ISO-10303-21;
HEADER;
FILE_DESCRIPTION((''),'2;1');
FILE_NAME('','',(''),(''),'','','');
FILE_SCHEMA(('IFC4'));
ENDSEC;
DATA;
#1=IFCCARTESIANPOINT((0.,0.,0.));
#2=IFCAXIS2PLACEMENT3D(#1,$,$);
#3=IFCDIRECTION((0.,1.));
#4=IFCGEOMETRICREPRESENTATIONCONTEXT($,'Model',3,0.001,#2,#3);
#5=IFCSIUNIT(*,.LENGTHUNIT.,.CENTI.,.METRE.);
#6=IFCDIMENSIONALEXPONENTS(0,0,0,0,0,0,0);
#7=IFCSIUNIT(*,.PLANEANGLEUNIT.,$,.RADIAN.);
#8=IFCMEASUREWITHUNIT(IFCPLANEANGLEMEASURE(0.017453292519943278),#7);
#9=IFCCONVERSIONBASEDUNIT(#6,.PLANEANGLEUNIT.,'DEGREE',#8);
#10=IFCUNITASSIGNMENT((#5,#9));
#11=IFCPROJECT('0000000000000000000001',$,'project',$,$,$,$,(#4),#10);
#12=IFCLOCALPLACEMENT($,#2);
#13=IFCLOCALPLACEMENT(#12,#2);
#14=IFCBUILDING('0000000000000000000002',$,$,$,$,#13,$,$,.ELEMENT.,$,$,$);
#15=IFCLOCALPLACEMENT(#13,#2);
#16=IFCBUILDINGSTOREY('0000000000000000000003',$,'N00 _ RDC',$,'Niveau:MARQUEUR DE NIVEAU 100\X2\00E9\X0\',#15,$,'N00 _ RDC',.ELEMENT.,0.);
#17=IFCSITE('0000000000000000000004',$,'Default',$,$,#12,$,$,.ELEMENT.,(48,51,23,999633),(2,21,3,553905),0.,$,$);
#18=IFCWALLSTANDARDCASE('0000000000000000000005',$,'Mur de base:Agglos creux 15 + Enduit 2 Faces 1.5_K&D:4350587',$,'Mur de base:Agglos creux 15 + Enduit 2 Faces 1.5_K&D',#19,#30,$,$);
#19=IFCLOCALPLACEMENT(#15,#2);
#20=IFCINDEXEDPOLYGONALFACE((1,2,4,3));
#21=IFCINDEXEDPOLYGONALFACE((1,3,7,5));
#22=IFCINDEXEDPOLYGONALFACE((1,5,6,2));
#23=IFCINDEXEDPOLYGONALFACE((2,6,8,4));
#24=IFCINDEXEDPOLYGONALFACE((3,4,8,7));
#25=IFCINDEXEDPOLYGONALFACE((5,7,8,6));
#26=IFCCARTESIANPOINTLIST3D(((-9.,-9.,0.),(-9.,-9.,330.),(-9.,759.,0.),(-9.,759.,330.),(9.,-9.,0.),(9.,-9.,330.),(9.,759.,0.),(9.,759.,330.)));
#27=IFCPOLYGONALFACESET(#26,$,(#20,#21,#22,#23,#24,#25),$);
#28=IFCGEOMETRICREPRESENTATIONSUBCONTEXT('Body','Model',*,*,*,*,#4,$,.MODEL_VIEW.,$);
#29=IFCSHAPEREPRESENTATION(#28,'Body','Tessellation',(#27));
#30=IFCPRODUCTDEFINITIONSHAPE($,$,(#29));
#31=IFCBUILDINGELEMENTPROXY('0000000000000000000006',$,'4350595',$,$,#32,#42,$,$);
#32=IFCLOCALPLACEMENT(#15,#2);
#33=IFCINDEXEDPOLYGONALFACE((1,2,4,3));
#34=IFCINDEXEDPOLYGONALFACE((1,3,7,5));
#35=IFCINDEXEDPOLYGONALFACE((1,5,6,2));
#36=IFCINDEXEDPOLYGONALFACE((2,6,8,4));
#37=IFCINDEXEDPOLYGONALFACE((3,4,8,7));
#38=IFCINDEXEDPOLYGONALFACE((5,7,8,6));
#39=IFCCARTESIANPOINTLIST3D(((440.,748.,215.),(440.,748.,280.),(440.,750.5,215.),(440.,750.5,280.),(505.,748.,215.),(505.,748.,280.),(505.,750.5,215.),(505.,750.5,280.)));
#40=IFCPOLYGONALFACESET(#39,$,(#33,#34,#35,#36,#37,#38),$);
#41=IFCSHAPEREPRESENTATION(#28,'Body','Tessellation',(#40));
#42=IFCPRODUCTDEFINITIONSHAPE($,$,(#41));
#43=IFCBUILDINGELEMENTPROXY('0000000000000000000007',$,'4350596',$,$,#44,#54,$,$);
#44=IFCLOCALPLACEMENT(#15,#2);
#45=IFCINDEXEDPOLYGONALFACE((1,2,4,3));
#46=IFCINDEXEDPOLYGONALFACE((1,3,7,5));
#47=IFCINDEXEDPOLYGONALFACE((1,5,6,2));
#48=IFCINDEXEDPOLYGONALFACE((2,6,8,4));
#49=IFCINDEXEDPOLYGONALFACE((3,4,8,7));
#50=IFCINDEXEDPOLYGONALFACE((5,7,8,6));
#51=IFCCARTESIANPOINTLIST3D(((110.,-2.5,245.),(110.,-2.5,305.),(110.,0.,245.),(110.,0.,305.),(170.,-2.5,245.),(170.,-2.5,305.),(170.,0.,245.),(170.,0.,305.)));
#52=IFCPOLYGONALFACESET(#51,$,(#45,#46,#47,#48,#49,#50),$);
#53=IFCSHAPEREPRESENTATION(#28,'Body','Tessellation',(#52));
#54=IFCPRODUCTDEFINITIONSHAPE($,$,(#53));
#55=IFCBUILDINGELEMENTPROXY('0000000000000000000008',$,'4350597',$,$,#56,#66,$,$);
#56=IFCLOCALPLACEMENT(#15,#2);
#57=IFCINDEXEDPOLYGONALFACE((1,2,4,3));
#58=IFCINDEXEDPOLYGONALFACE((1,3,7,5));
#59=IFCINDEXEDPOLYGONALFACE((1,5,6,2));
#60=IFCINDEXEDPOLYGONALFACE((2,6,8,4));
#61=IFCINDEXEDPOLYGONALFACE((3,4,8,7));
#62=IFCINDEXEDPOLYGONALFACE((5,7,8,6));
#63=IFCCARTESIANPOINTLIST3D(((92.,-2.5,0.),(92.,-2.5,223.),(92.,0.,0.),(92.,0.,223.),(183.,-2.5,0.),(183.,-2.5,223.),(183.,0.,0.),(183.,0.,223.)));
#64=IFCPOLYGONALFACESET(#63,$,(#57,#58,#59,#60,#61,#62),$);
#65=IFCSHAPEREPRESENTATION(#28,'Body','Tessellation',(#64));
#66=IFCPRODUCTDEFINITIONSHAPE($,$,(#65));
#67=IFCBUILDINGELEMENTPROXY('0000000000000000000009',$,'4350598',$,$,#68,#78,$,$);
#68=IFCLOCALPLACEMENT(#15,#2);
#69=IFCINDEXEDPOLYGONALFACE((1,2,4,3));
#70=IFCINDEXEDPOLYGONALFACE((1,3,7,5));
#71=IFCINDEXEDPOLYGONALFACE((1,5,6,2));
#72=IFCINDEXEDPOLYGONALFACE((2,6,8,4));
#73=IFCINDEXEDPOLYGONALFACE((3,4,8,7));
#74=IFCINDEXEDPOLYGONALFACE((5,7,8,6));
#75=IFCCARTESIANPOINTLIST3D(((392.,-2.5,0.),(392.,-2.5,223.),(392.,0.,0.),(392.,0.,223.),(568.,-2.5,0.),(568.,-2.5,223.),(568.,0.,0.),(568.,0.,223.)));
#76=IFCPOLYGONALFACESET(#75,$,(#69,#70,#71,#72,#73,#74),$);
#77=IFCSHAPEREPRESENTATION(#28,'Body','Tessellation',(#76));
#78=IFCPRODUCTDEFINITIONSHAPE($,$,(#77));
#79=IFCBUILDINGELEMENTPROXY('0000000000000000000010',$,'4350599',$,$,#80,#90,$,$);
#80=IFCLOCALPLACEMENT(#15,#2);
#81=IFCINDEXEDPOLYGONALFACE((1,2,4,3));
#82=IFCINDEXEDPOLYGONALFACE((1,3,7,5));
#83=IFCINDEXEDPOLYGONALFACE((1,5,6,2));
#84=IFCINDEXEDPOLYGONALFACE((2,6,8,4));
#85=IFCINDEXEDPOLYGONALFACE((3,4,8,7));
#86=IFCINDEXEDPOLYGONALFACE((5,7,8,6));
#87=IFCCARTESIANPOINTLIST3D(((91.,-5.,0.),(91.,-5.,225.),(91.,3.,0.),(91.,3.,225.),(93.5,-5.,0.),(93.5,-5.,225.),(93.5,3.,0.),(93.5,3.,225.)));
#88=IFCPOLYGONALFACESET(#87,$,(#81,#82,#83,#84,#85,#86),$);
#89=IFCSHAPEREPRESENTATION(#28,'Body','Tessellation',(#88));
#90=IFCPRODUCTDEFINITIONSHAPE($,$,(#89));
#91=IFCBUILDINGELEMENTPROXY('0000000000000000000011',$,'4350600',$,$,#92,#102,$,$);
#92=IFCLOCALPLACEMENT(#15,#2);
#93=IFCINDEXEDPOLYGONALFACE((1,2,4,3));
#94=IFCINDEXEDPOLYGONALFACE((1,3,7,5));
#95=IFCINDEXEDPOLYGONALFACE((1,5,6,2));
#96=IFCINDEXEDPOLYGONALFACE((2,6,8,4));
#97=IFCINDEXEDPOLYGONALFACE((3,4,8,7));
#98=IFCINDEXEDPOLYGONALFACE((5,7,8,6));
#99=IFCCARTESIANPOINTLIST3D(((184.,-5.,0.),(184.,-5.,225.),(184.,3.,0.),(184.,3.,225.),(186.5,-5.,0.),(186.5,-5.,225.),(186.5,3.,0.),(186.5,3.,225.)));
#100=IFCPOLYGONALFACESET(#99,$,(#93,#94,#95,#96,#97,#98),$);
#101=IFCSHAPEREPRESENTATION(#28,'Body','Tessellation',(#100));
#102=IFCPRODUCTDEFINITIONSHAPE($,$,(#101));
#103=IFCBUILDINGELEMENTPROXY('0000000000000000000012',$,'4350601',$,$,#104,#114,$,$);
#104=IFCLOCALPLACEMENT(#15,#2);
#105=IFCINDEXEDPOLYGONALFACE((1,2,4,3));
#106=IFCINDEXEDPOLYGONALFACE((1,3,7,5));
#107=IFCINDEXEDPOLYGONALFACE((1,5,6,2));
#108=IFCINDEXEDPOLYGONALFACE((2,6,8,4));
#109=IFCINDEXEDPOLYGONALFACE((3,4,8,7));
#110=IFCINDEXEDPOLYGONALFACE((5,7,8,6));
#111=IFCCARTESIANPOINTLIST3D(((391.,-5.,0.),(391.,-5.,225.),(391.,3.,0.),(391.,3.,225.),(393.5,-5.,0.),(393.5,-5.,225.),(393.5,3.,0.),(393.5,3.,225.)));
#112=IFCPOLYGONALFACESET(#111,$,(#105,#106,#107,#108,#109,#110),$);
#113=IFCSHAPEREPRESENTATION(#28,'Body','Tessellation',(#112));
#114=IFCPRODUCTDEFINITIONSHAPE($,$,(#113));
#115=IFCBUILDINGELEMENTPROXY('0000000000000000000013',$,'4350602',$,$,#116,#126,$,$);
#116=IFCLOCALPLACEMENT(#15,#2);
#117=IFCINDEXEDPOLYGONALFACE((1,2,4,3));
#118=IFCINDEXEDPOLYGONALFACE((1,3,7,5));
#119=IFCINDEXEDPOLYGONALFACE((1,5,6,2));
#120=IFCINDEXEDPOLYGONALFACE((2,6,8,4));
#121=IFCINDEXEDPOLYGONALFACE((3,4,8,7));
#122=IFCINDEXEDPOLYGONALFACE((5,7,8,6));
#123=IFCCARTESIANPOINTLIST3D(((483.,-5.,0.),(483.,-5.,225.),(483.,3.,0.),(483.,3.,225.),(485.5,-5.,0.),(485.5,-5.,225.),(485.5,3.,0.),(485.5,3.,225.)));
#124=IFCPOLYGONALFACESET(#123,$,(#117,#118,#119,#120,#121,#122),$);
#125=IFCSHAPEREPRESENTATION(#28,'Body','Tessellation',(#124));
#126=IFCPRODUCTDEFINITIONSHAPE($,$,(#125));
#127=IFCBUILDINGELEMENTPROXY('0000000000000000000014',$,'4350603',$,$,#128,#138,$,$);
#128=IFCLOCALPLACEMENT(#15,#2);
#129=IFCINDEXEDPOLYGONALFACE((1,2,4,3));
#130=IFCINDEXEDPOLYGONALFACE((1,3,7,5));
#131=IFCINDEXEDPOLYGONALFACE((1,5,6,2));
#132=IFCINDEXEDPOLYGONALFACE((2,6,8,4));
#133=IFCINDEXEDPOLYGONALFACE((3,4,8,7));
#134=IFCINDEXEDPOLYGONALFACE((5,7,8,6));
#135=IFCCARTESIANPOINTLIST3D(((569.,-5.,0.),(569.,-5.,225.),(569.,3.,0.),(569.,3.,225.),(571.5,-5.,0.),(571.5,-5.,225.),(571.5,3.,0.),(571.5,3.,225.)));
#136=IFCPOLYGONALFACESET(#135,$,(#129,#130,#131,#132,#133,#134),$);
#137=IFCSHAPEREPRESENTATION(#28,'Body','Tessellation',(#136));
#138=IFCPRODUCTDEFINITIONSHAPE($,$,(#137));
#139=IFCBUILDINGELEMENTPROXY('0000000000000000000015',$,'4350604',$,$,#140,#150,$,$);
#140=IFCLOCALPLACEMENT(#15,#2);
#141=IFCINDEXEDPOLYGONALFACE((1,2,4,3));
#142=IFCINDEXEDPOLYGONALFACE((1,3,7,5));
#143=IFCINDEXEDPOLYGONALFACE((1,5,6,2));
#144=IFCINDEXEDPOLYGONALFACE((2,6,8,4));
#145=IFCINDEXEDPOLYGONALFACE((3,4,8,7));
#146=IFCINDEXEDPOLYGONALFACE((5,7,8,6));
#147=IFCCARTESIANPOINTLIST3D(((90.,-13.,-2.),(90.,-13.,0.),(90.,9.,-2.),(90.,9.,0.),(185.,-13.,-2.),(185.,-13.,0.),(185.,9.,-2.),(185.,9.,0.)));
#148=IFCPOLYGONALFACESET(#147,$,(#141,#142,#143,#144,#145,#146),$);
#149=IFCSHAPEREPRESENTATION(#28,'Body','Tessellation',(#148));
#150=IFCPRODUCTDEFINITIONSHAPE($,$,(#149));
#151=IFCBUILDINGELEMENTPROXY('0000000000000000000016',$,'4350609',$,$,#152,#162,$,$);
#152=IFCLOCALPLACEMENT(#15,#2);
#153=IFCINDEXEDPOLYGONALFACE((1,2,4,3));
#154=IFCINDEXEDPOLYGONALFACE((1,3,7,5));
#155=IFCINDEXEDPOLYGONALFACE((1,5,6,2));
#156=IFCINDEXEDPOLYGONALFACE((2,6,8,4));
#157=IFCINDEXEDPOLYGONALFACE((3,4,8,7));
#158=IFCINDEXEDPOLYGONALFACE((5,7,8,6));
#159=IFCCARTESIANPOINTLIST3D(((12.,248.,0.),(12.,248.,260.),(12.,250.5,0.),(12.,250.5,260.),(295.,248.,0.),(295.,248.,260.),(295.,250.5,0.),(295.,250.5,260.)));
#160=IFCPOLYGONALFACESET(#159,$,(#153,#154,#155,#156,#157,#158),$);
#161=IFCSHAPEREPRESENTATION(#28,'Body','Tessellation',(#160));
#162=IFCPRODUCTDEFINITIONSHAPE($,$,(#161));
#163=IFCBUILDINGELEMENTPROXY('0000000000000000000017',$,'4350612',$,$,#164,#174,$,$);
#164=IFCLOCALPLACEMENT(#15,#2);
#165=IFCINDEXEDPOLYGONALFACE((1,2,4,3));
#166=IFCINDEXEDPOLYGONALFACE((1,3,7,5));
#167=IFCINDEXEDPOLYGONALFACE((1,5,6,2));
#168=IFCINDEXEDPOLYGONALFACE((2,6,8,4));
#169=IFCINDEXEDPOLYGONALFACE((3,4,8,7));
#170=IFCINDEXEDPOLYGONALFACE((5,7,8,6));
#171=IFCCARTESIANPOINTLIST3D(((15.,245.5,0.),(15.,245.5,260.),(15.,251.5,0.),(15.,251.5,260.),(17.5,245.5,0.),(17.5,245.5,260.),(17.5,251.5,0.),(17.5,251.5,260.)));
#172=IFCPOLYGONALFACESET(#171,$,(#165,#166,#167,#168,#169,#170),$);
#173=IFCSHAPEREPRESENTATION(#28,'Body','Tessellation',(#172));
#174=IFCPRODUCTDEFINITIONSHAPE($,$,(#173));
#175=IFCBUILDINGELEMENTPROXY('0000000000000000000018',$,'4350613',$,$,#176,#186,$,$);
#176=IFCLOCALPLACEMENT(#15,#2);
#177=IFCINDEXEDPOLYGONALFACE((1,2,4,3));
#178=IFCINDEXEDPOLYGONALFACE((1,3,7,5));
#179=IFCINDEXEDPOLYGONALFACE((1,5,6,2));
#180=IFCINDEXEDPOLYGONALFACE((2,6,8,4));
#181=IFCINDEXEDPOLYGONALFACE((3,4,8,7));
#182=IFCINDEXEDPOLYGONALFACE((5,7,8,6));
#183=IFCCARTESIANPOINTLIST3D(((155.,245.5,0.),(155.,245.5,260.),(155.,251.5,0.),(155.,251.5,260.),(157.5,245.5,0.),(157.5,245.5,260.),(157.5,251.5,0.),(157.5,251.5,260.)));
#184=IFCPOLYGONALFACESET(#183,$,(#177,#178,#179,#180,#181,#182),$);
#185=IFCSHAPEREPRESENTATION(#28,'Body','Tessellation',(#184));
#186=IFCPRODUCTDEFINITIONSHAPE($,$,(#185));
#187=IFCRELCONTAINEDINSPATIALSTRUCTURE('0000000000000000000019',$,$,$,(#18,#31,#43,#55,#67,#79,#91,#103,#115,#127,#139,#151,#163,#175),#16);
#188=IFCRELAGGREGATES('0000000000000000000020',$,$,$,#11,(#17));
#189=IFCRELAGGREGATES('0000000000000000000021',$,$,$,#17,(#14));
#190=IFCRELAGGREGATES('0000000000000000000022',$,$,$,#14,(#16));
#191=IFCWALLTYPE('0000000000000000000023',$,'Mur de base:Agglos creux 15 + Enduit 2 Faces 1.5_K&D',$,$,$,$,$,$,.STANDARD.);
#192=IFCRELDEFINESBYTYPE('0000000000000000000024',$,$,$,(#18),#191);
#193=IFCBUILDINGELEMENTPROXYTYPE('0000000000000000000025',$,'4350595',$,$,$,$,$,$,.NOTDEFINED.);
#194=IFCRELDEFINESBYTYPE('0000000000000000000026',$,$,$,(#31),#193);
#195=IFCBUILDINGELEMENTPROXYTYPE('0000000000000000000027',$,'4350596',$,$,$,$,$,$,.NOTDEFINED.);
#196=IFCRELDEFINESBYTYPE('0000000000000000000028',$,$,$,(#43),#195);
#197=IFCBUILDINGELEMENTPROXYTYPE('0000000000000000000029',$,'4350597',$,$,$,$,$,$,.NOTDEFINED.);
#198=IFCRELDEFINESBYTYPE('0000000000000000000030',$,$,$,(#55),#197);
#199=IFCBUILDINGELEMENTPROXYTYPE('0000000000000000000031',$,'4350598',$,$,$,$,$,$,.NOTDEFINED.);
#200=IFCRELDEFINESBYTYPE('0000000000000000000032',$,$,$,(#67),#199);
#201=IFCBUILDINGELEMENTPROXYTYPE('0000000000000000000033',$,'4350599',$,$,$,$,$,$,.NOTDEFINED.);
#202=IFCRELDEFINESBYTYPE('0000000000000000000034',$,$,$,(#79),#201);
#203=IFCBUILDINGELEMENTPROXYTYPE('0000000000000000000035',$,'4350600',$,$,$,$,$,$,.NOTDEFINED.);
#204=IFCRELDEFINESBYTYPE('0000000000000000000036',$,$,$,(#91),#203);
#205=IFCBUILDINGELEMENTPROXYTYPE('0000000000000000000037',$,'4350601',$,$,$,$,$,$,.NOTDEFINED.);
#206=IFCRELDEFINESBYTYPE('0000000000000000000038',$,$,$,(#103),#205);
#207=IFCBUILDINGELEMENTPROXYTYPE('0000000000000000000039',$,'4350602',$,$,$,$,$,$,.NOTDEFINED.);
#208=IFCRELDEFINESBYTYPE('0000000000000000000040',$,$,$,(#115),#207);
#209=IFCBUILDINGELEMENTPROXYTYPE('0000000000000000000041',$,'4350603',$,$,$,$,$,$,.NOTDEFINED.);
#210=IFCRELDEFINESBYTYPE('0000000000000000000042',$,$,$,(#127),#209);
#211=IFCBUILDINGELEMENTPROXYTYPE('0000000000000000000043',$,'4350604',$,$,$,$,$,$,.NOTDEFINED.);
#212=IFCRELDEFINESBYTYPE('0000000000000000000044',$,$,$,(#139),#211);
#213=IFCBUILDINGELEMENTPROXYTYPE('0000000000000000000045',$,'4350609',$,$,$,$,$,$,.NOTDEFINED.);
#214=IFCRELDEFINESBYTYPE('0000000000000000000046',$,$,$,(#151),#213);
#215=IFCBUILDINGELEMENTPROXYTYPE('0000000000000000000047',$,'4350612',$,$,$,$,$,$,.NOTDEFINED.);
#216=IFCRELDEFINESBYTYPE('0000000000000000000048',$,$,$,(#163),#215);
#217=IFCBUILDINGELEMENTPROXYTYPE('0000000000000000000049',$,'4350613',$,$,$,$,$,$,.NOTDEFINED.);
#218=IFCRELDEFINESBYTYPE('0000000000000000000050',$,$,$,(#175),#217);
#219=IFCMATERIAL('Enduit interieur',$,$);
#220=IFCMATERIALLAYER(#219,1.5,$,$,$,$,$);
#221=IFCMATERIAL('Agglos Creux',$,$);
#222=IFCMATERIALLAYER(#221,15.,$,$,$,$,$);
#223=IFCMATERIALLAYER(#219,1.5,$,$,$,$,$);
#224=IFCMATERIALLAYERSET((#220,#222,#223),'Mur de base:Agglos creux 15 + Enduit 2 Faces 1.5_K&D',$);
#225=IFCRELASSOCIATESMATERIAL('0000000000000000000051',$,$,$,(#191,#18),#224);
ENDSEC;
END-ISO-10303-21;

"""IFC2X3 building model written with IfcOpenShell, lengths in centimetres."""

from ifc_helpers import new_model, entity, si_unit, converted_unit, direction, frame, frame_2d, origin, origin_2d_with_axis, place, context, subcontext, project, spatial, rectangle, extrude, material, layer, layer_set, layer_usage, type_object, element, save


model = new_model("IFC2X3")

# Units and contexts
model_context = context("Model", 3, precision=0.001, world=origin(), true_north=direction((0.0, 1.0)))
body_context = subcontext(model_context, "Body", "Model", "MODEL_VIEW")
ifc_project = project(units=[si_unit("LENGTHUNIT", "METRE", prefix="CENTI"), converted_unit("PLANEANGLEUNIT", "DEGREE", entity("IfcPlaneAngleMeasure", 0.017453292519943278), si_unit("PLANEANGLEUNIT", "RADIAN"), dimensions=[0, 0, 0, 0, 0, 0, 0])], contexts=[model_context])

# Site, building, storey
site_placement = place(None, origin())
site = spatial("IfcSite", under=ifc_project, at=site_placement, Name="Default", CompositionType="ELEMENT", RefLatitude=(48, 51, 23, 999633), RefLongitude=(2, 21, 3, 553905), RefElevation=0.0)
building_placement = place(site_placement, origin())
building = spatial("IfcBuilding", under=site, at=building_placement, CompositionType="ELEMENT")
storey_placement = place(building_placement, origin())
storey = spatial("IfcBuildingStorey", under=building, at=storey_placement, Name="N00 _ RDC", ObjectType="Niveau:MARQUEUR DE NIVEAU 100é", LongName="N00 _ RDC", CompositionType="ELEMENT", Elevation=0.0)

# Wall
ifc_material_1 = material(Name="Enduit interieur")
ifc_layer_1 = layer(ifc_material_1, 1.5)
ifc_material_2 = material(Name="Agglos Creux")
ifc_layer_2 = layer(ifc_material_2, 15.0)
ifc_layer_3 = layer(ifc_material_1, 1.5)
ifc_layer_set = layer_set([ifc_layer_1, ifc_layer_2, ifc_layer_3], Name="Mur de base:Agglos creux 15 + Enduit 2 Faces 1.5_K&D")
ifc_layer_usage = layer_usage(ifc_layer_set, "AXIS2", "NEGATIVE", 9.0)
wall_type = type_object("IfcWallType", Name="Mur de base:Agglos creux 15 + Enduit 2 Faces 1.5_K&D", PredefinedType="STANDARD", material=ifc_layer_set)
wall_placement = place(storey_placement, frame((0.0, -9.0, 0.0), z_axis=(0.0, 0.0, 1.0), x_axis=(0.0, 1.0, 0.0)))
element("IfcWallStandardCase", 1, at=wall_placement, inside=storey, type_object=wall_type, material=ifc_layer_usage, Name="Mur de base:Agglos creux 15 + Enduit 2 Faces 1.5_K&D:4350587", ObjectType="Mur de base:Agglos creux 15 + Enduit 2 Faces 1.5_K&D", context=body_context, shape_type="SweptSolid", body=[
    extrude(rectangle(XDim=768.0, YDim=18.0, at=frame_2d((384.0, 0.0), x_axis=(-1.0, 0.0))), origin(), (0.0, 0.0, 1.0), 330.0),
])

# Building element proxies
building_element_proxy_type_1 = type_object("IfcBuildingElementProxyType", Name="4350595", PredefinedType="NOTDEFINED")
proxy_1_placement = place(storey_placement, origin())
element("IfcBuildingElementProxy", 2, at=proxy_1_placement, inside=storey, type_object=building_element_proxy_type_1, Name="4350595", context=body_context, shape_type="SweptSolid", body=[
    extrude(rectangle(XDim=65.0, YDim=2.5, at=frame_2d((0.0, 0.0), x_axis=(1.0, 0.0))), frame((472.5, 749.25, 215.0)), (0.0, 0.0, 1.0), 65.0),
])
building_element_proxy_type_2 = type_object("IfcBuildingElementProxyType", Name="4350596", PredefinedType="NOTDEFINED")
proxy_2_placement = place(storey_placement, origin())
element("IfcBuildingElementProxy", 3, at=proxy_2_placement, inside=storey, type_object=building_element_proxy_type_2, Name="4350596", context=body_context, shape_type="SweptSolid", body=[
    extrude(rectangle(XDim=60.0, YDim=2.5, at=origin_2d_with_axis()), frame((140.0, -1.25, 245.0)), (0.0, 0.0, 1.0), 60.0),
])
building_element_proxy_type_3 = type_object("IfcBuildingElementProxyType", Name="4350597", PredefinedType="NOTDEFINED")
proxy_3_placement = place(storey_placement, origin())
element("IfcBuildingElementProxy", 4, at=proxy_3_placement, inside=storey, type_object=building_element_proxy_type_3, Name="4350597", context=body_context, shape_type="SweptSolid", body=[
    extrude(rectangle(XDim=91.0, YDim=2.5, at=frame_2d((0.0, 0.0), x_axis=(1.0, 0.0))), frame((137.5, -1.25, 0.0)), (0.0, 0.0, 1.0), 223.0),
])
building_element_proxy_type_4 = type_object("IfcBuildingElementProxyType", Name="4350598", PredefinedType="NOTDEFINED")
proxy_4_placement = place(storey_placement, origin())
element("IfcBuildingElementProxy", 5, at=proxy_4_placement, inside=storey, type_object=building_element_proxy_type_4, Name="4350598", context=body_context, shape_type="SweptSolid", body=[
    extrude(rectangle(XDim=176.0, YDim=2.5, at=frame_2d((0.0, 0.0), x_axis=(1.0, 0.0))), frame((480.0, -1.25, 0.0)), (0.0, 0.0, 1.0), 223.0),
])
building_element_proxy_type_5 = type_object("IfcBuildingElementProxyType", Name="4350599", PredefinedType="NOTDEFINED")
proxy_5_placement = place(storey_placement, origin())
element("IfcBuildingElementProxy", 6, at=proxy_5_placement, inside=storey, type_object=building_element_proxy_type_5, Name="4350599", context=body_context, shape_type="SweptSolid", body=[
    extrude(rectangle(XDim=2.5, YDim=8.0, at=frame_2d((0.0, 0.0), x_axis=(1.0, 0.0))), frame((92.25, -1.0, 0.0)), (0.0, 0.0, 1.0), 225.0),
])
building_element_proxy_type_6 = type_object("IfcBuildingElementProxyType", Name="4350600", PredefinedType="NOTDEFINED")
proxy_6_placement = place(storey_placement, origin())
element("IfcBuildingElementProxy", 7, at=proxy_6_placement, inside=storey, type_object=building_element_proxy_type_6, Name="4350600", context=body_context, shape_type="SweptSolid", body=[
    extrude(rectangle(XDim=2.5, YDim=8.0, at=frame_2d((0.0, 0.0), x_axis=(1.0, 0.0))), frame((185.25, -1.0, 0.0)), (0.0, 0.0, 1.0), 225.0),
])
building_element_proxy_type_7 = type_object("IfcBuildingElementProxyType", Name="4350601", PredefinedType="NOTDEFINED")
proxy_7_placement = place(storey_placement, origin())
element("IfcBuildingElementProxy", 8, at=proxy_7_placement, inside=storey, type_object=building_element_proxy_type_7, Name="4350601", context=body_context, shape_type="SweptSolid", body=[
    extrude(rectangle(XDim=2.5, YDim=8.0, at=frame_2d((0.0, 0.0), x_axis=(1.0, 0.0))), frame((392.25, -1.0, 0.0)), (0.0, 0.0, 1.0), 225.0),
])
building_element_proxy_type_8 = type_object("IfcBuildingElementProxyType", Name="4350602", PredefinedType="NOTDEFINED")
proxy_8_placement = place(storey_placement, origin())
element("IfcBuildingElementProxy", 9, at=proxy_8_placement, inside=storey, type_object=building_element_proxy_type_8, Name="4350602", context=body_context, shape_type="SweptSolid", body=[
    extrude(rectangle(XDim=2.5, YDim=8.0, at=frame_2d((0.0, 0.0), x_axis=(1.0, 0.0))), frame((484.25, -1.0, 0.0)), (0.0, 0.0, 1.0), 225.0),
])
building_element_proxy_type_9 = type_object("IfcBuildingElementProxyType", Name="4350603", PredefinedType="NOTDEFINED")
proxy_9_placement = place(storey_placement, origin())
element("IfcBuildingElementProxy", 10, at=proxy_9_placement, inside=storey, type_object=building_element_proxy_type_9, Name="4350603", context=body_context, shape_type="SweptSolid", body=[
    extrude(rectangle(XDim=2.5, YDim=8.0, at=frame_2d((0.0, 0.0), x_axis=(1.0, 0.0))), frame((570.25, -1.0, 0.0)), (0.0, 0.0, 1.0), 225.0),
])
building_element_proxy_type_10 = type_object("IfcBuildingElementProxyType", Name="4350604", PredefinedType="NOTDEFINED")
proxy_10_placement = place(storey_placement, origin())
element("IfcBuildingElementProxy", 11, at=proxy_10_placement, inside=storey, type_object=building_element_proxy_type_10, Name="4350604", context=body_context, shape_type="SweptSolid", body=[
    extrude(rectangle(XDim=95.0, YDim=22.0, at=origin_2d_with_axis()), frame((137.5, -2.0, -2.0)), (0.0, 0.0, 1.0), 2.0),
])
building_element_proxy_type_11 = type_object("IfcBuildingElementProxyType", Name="4350609", PredefinedType="NOTDEFINED")
proxy_11_placement = place(storey_placement, origin())
element("IfcBuildingElementProxy", 12, at=proxy_11_placement, inside=storey, type_object=building_element_proxy_type_11, Name="4350609", context=body_context, shape_type="SweptSolid", body=[
    extrude(rectangle(XDim=283.0, YDim=2.5, at=frame_2d((0.0, 0.0), x_axis=(1.0, 0.0))), frame((153.5, 249.25, 0.0)), (0.0, 0.0, 1.0), 260.0),
])
building_element_proxy_type_12 = type_object("IfcBuildingElementProxyType", Name="4350612", PredefinedType="NOTDEFINED")
proxy_12_placement = place(storey_placement, origin())
element("IfcBuildingElementProxy", 13, at=proxy_12_placement, inside=storey, type_object=building_element_proxy_type_12, Name="4350612", context=body_context, shape_type="SweptSolid", body=[
    extrude(rectangle(XDim=2.5, YDim=6.0, at=frame_2d((0.0, 0.0), x_axis=(1.0, 0.0))), frame((16.25, 248.5, 0.0)), (0.0, 0.0, 1.0), 260.0),
])
building_element_proxy_type_13 = type_object("IfcBuildingElementProxyType", Name="4350613", PredefinedType="NOTDEFINED")
proxy_13_placement = place(storey_placement, origin())
element("IfcBuildingElementProxy", 14, at=proxy_13_placement, inside=storey, type_object=building_element_proxy_type_13, Name="4350613", context=body_context, shape_type="SweptSolid", body=[
    extrude(rectangle(XDim=2.5, YDim=6.0, at=frame_2d((0.0, 0.0), x_axis=(1.0, 0.0))), frame((156.25, 248.5, 0.0)), (0.0, 0.0, 1.0), 260.0),
])

save(model, "model.ifc")
